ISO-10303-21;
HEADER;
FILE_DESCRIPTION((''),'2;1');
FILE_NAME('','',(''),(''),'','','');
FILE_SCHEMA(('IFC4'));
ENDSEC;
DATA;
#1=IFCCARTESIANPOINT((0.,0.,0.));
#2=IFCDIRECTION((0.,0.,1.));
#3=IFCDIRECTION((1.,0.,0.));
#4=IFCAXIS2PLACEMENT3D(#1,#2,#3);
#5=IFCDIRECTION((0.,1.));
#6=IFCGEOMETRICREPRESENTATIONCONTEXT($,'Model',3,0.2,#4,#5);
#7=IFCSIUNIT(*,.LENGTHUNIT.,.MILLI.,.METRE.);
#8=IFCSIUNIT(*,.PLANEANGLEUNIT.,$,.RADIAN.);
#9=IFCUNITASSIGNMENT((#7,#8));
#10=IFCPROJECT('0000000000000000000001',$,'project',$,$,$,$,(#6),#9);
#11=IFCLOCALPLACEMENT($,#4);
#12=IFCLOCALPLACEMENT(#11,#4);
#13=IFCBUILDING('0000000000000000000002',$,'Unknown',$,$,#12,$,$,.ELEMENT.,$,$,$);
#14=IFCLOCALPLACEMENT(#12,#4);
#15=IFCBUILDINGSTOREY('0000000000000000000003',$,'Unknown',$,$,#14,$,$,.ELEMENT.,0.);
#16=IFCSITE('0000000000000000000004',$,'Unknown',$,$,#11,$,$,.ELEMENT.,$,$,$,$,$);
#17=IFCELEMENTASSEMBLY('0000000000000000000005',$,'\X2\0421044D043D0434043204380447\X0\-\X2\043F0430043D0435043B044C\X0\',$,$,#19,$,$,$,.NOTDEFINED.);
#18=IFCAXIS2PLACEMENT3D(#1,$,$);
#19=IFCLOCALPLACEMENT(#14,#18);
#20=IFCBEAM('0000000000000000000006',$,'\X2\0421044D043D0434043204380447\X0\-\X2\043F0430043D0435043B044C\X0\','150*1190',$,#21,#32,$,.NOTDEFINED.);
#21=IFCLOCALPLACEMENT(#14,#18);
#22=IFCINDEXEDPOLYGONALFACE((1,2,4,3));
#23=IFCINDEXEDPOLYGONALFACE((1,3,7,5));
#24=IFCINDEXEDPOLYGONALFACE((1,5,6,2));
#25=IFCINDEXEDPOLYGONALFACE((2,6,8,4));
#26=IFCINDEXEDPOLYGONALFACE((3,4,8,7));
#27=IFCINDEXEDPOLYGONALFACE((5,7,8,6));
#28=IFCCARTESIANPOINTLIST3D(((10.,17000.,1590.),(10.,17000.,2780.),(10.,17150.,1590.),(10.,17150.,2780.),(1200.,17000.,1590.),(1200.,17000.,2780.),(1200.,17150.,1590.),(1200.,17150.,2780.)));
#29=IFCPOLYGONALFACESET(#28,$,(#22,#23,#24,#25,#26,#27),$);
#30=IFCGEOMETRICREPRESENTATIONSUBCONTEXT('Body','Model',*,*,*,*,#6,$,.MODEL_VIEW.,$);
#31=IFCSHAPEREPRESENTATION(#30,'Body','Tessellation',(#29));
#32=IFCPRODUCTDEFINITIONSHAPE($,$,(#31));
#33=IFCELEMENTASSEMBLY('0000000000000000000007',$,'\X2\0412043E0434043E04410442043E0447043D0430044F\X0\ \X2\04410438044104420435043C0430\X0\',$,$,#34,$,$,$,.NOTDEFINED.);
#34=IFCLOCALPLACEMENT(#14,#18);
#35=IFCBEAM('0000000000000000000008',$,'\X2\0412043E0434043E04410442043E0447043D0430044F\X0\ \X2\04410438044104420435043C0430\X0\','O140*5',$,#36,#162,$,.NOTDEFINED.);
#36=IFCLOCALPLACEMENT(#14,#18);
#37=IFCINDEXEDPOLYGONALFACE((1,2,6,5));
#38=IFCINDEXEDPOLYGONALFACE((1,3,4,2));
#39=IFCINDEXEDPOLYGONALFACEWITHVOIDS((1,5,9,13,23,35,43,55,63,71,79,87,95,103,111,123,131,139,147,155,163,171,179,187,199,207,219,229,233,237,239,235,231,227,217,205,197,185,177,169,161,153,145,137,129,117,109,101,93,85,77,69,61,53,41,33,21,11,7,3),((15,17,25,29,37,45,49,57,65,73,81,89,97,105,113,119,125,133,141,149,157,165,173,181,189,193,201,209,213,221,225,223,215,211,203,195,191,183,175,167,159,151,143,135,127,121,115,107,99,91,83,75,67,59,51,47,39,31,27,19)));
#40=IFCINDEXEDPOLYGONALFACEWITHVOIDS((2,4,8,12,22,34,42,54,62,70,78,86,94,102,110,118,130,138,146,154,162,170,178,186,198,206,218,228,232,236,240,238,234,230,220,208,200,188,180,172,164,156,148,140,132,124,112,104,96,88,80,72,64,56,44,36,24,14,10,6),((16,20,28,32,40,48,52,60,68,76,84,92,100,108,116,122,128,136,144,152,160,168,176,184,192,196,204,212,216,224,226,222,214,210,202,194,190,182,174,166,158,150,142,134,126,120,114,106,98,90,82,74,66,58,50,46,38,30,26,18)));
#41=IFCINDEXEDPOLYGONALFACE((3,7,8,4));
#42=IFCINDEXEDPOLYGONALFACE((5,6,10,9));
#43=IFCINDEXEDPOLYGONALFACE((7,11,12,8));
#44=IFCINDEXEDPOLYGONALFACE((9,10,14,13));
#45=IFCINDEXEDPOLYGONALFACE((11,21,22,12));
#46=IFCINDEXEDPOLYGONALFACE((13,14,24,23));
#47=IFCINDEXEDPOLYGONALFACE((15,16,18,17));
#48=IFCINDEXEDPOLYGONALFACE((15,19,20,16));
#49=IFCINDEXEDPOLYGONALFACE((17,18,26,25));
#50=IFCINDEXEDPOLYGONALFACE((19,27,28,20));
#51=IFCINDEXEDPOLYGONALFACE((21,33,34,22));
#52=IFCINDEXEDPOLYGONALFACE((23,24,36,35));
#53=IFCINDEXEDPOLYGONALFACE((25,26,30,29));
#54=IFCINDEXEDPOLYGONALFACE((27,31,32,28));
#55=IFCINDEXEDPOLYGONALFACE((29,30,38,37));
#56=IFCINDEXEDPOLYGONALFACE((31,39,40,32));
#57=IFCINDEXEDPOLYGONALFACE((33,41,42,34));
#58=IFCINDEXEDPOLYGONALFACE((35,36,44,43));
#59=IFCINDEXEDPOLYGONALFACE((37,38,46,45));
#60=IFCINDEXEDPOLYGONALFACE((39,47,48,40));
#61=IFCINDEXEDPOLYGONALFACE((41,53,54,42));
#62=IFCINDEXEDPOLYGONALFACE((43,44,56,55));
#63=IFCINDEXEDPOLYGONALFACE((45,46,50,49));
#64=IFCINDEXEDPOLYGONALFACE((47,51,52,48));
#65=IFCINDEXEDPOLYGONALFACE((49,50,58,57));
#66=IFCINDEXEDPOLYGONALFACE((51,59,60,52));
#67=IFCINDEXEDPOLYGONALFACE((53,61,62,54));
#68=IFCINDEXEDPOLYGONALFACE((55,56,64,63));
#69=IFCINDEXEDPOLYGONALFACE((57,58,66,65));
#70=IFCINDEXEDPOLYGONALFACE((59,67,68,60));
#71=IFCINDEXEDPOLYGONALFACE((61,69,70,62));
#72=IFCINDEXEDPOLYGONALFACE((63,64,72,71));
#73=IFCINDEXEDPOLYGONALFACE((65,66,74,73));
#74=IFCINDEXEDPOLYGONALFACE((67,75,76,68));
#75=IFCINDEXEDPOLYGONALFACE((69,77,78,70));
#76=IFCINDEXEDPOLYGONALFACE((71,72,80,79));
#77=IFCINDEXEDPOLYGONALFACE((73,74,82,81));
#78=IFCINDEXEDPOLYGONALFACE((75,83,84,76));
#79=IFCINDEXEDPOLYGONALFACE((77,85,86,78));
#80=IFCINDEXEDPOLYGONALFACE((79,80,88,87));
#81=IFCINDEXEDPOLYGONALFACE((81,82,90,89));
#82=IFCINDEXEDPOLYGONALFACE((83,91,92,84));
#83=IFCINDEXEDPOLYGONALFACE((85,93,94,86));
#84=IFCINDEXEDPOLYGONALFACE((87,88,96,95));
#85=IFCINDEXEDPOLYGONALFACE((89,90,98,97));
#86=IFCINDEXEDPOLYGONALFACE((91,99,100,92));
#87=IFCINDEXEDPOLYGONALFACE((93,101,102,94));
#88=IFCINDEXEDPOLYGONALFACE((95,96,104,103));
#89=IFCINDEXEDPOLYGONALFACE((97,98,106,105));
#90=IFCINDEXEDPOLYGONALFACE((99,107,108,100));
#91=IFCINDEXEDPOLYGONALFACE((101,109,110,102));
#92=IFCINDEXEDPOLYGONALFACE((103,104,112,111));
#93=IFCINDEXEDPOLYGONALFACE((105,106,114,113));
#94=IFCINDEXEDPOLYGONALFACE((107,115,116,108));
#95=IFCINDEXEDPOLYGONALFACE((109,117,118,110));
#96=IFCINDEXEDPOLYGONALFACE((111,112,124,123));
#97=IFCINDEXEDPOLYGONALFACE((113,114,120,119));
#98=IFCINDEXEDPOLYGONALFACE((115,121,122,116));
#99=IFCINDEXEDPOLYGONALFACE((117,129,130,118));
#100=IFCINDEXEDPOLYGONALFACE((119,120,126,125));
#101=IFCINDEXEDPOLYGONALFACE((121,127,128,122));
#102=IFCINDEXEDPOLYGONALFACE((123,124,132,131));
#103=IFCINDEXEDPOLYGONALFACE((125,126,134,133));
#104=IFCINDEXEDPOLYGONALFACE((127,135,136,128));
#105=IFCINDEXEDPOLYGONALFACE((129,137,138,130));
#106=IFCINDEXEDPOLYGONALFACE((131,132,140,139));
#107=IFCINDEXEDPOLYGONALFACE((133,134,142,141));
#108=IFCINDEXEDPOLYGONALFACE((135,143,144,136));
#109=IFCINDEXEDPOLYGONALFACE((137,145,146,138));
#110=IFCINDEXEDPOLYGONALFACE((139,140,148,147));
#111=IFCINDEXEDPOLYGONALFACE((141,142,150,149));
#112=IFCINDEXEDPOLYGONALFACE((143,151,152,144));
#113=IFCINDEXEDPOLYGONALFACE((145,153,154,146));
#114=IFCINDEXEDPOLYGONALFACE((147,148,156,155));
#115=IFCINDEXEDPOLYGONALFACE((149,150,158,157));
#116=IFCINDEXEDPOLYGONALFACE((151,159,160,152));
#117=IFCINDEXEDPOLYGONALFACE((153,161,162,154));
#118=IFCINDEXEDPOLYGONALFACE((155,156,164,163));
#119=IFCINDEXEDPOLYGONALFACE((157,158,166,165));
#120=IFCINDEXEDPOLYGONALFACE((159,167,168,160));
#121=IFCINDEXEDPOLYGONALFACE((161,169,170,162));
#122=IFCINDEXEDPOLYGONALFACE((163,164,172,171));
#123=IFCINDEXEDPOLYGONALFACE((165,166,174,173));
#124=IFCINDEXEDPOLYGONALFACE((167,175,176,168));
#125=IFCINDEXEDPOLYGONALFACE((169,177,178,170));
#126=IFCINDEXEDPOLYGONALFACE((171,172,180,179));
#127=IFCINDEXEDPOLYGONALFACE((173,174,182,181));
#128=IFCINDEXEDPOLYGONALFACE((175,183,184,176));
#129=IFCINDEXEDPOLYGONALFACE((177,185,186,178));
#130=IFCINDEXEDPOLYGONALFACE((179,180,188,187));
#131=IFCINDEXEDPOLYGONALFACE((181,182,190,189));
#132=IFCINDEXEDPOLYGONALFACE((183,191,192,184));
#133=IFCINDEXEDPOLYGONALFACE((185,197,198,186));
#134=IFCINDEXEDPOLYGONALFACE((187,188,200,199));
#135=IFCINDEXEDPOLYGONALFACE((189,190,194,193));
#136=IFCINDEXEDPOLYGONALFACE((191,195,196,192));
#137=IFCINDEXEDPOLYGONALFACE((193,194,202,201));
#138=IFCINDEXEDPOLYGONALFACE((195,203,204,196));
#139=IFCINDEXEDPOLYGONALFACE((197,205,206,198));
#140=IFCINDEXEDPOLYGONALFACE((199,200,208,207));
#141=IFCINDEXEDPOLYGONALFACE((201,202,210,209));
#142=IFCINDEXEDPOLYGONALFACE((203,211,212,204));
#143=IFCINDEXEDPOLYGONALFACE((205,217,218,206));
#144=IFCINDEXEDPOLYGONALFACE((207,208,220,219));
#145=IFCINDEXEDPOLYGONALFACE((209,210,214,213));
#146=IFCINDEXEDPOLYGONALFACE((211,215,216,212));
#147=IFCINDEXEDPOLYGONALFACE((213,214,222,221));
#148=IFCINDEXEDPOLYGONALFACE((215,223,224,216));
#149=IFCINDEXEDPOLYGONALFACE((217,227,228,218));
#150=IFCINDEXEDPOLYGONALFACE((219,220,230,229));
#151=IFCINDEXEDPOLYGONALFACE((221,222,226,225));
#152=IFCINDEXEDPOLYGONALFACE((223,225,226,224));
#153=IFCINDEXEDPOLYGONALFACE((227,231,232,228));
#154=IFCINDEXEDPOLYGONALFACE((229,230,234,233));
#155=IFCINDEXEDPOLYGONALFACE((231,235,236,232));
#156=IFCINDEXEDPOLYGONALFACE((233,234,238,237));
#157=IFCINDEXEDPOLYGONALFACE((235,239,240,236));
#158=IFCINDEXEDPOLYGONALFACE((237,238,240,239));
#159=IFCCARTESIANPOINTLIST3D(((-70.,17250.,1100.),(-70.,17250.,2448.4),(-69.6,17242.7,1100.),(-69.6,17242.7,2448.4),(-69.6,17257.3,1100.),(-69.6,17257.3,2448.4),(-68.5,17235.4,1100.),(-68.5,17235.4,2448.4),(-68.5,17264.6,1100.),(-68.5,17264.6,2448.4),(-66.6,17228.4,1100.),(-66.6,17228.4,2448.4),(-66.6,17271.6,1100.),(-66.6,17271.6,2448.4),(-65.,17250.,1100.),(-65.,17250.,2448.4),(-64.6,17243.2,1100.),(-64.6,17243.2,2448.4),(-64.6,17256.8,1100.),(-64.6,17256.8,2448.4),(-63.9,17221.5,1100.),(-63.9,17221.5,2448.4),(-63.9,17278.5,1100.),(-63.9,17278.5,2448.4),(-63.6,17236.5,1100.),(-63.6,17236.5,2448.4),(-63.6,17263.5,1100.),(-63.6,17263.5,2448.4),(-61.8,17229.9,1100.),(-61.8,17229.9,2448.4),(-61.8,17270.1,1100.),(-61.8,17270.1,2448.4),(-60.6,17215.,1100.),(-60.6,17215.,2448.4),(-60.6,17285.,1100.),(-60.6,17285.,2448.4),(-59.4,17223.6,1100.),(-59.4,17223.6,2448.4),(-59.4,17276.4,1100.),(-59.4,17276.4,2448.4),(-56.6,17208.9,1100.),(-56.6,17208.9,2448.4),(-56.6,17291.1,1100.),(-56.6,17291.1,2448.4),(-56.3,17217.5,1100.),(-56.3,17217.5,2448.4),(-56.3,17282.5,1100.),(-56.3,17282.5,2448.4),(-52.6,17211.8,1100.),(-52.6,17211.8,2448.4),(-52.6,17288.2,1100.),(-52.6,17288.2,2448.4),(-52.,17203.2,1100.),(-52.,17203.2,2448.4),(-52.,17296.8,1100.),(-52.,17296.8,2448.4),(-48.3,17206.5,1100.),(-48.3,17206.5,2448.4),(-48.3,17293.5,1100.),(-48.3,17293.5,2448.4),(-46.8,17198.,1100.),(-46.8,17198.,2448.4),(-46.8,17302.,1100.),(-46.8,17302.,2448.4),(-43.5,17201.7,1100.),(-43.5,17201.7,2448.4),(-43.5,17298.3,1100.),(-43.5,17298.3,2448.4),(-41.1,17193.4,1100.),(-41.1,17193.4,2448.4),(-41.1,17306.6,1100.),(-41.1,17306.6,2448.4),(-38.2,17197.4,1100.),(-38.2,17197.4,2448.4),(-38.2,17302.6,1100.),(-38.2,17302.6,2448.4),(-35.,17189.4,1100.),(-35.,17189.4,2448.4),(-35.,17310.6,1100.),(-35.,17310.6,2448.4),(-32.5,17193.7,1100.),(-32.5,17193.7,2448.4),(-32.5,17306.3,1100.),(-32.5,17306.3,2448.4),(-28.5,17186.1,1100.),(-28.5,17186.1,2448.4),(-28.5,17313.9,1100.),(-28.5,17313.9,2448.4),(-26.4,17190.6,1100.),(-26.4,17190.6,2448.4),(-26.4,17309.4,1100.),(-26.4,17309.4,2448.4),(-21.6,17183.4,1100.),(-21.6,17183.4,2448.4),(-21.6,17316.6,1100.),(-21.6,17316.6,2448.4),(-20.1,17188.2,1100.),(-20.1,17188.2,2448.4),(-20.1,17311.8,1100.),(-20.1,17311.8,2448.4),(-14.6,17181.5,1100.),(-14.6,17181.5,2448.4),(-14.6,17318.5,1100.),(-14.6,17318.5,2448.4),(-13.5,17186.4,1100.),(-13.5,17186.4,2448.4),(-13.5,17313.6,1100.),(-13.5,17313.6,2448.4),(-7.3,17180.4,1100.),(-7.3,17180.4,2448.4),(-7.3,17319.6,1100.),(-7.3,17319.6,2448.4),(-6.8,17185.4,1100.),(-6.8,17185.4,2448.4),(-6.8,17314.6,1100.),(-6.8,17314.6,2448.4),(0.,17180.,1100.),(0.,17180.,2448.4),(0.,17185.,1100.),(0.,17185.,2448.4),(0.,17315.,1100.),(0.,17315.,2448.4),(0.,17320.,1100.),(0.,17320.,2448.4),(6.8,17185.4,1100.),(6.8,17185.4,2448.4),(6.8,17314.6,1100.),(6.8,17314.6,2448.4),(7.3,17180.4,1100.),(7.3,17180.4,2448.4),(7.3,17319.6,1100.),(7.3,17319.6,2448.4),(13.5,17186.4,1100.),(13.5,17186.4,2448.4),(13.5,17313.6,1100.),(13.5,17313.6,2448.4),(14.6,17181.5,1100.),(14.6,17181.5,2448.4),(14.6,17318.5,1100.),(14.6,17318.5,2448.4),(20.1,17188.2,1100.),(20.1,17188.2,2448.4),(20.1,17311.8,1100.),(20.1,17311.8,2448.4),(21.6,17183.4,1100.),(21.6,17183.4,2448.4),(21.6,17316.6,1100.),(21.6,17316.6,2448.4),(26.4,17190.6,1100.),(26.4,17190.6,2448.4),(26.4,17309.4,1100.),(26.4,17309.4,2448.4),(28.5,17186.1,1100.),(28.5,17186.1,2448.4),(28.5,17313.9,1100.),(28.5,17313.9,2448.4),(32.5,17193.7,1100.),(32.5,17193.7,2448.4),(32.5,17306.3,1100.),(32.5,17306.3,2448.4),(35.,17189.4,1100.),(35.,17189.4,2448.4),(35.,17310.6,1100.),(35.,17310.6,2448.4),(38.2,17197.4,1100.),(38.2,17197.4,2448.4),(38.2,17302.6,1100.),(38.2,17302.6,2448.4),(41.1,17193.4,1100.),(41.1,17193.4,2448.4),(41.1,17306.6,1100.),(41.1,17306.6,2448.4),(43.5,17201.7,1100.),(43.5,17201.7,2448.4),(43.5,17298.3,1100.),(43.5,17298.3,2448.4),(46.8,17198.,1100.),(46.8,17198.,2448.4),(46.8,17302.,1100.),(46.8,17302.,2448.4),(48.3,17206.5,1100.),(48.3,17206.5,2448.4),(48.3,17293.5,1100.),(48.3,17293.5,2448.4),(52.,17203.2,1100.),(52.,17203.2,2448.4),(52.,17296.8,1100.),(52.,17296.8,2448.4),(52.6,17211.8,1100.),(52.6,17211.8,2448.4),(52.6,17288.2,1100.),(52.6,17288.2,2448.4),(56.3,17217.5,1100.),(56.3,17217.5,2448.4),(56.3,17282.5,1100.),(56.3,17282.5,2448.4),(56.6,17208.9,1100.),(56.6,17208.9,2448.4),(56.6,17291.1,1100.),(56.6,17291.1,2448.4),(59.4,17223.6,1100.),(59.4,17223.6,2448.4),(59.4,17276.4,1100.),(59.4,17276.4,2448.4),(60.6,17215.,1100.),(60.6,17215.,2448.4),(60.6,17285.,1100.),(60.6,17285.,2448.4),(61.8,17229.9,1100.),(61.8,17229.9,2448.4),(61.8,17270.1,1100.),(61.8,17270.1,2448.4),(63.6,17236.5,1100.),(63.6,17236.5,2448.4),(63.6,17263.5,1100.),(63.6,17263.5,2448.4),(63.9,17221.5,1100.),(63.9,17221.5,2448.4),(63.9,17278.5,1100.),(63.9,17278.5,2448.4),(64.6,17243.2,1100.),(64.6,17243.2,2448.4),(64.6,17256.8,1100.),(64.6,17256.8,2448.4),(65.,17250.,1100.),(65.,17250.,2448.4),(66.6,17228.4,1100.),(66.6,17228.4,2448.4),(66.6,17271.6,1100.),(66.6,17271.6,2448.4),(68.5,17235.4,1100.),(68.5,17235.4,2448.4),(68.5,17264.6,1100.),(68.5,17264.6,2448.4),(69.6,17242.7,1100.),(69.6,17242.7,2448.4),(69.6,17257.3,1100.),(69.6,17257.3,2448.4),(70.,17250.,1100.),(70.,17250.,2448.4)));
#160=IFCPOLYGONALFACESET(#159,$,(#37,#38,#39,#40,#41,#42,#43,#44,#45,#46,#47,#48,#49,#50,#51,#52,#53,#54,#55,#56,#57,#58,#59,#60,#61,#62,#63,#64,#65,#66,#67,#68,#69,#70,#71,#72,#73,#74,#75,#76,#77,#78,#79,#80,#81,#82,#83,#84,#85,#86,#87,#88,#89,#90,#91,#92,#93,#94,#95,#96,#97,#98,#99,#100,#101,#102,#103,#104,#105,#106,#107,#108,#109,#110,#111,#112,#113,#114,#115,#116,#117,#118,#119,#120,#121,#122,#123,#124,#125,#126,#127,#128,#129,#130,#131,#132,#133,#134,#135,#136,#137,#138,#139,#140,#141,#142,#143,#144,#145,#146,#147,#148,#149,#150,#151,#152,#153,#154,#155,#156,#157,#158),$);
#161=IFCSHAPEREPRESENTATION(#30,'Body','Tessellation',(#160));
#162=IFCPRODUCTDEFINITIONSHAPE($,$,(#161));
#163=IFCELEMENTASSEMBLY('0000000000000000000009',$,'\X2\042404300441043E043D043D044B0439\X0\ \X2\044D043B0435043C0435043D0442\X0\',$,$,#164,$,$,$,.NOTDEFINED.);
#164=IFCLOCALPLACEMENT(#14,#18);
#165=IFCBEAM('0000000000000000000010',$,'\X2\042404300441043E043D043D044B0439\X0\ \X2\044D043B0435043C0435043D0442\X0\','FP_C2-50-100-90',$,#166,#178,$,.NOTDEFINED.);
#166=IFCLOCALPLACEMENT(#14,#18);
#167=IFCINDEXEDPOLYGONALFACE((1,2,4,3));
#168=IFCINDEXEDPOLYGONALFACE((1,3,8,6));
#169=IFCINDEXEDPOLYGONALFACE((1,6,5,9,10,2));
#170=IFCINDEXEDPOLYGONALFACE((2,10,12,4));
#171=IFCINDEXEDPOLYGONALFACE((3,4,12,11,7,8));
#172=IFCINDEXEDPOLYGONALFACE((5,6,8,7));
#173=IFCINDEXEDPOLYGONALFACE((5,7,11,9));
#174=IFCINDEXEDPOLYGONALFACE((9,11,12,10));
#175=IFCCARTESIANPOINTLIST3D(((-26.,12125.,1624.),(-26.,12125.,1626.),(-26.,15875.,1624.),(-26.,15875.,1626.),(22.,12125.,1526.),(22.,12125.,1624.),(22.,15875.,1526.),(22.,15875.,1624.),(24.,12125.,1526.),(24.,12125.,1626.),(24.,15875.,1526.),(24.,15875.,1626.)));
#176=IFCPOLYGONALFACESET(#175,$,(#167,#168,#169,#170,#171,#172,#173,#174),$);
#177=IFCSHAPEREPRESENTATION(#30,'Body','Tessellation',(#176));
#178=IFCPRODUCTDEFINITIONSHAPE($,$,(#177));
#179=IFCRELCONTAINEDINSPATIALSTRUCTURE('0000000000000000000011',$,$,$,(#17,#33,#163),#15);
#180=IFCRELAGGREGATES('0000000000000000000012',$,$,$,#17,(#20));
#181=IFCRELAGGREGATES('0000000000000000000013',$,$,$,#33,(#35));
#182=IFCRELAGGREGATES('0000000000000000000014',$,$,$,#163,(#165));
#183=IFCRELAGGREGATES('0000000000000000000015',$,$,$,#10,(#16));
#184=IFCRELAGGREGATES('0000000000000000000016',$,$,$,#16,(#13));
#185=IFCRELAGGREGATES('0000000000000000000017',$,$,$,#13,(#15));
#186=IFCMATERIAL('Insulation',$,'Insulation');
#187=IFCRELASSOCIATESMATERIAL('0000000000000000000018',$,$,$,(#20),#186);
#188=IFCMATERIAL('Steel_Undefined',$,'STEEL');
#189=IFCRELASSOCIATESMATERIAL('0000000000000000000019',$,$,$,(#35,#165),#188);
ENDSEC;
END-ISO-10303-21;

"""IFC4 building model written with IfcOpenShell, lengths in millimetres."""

from ifc_helpers import new_model, si_unit, direction, frame, origin_with_axes, place, context, subcontext, project, spatial, line, indexed_curve, outline, extrude, material, element, aggregate, save


model = new_model("IFC4")

# Units and contexts
model_context = context("Model", 3, precision=0.2, world=origin_with_axes(), true_north=direction((0.0, 1.0)))
body_context = subcontext(model_context, "Body", "Model", "MODEL_VIEW")
ifc_project = project(units=[si_unit("LENGTHUNIT", "METRE", prefix="MILLI"), si_unit("PLANEANGLEUNIT", "RADIAN")], contexts=[model_context])

# Site, building, storey
site_placement = place(None, origin_with_axes())
site = spatial("IfcSite", under=ifc_project, at=site_placement, Name="Unknown", CompositionType="ELEMENT")
building_placement = place(site_placement, origin_with_axes())
building = spatial("IfcBuilding", under=site, at=building_placement, Name="Unknown", CompositionType="ELEMENT")
storey_placement = place(building_placement, origin_with_axes())
storey = spatial("IfcBuildingStorey", under=building, at=storey_placement, Name="Unknown", CompositionType="ELEMENT", Elevation=0.0)

# Element assemblies, beams
assembly_1_placement = place(storey_placement, frame((10.0, 17075.0, 2185.0), z_axis=(0.0, 0.0, -1.0), x_axis=(1.0, 0.0, 0.0)))
assembly_1 = element("IfcElementAssembly", 1, at=assembly_1_placement, inside=storey, Name="Сэндвич-панель", PredefinedType="NOTDEFINED")
ifc_material_1 = material(Name="Insulation", Category="Insulation")
beam_1_placement = place(assembly_1_placement, origin_with_axes())
beam_1 = element("IfcBeam", 2, at=beam_1_placement, material=ifc_material_1, Name="Сэндвич-панель", Description="150*1190", PredefinedType="NOTDEFINED", context=body_context, shape_type="SolidModel", body=[
    extrude(outline(indexed_curve([(-595.0, -75.0), (595.0, -75.0), (595.0, 75.0), (-595.0, 75.0)], segments=[line(1, 2, 3, 4, 1)])), frame((0.0, 0.0, 0.0), z_axis=(-1.0, 0.0, 0.0), x_axis=(0.0, 0.0, 1.0)), (0.0, 0.0, -1.0), 1190.0),
])
aggregate(assembly_1, [beam_1])
assembly_2_placement = place(storey_placement, frame((0.0, 17250.0, 2448.4), z_axis=(0.0, -1.0, 0.0), x_axis=(0.0, 0.0, -1.0)))
assembly_2 = element("IfcElementAssembly", 3, at=assembly_2_placement, inside=storey, Name="Водосточная система", PredefinedType="NOTDEFINED")
ifc_material_2 = material(Name="Steel_Undefined", Category="STEEL")
beam_2_placement = place(assembly_2_placement, origin_with_axes())
beam_2 = element("IfcBeam", 4, at=beam_2_placement, material=ifc_material_2, Name="Водосточная система", Description="O140*5", PredefinedType="NOTDEFINED", context=body_context, shape_type="SolidModel", body=[
    extrude(outline(indexed_curve([(70.0, 0.0), (69.6, 7.3), (68.5, 14.6), (66.6, 21.6), (63.9, 28.5), (60.6, 35.0), (56.6, 41.1), (52.0, 46.8), (46.8, 52.0), (41.1, 56.6), (35.0, 60.6), (28.5, 63.9), (21.6, 66.6), (14.6, 68.5), (7.3, 69.6), (0.0, 70.0), (-7.3, 69.6), (-14.6, 68.5), (-21.6, 66.6), (-28.5, 63.9), (-35.0, 60.6), (-41.1, 56.6), (-46.8, 52.0), (-52.0, 46.8), (-56.6, 41.1), (-60.6, 35.0), (-63.9, 28.5), (-66.6, 21.6), (-68.5, 14.6), (-69.6, 7.3), (-70.0, 0.0), (-69.6, -7.3), (-68.5, -14.6), (-66.6, -21.6), (-63.9, -28.5), (-60.6, -35.0), (-56.6, -41.1), (-52.0, -46.8), (-46.8, -52.0), (-41.1, -56.6), (-35.0, -60.6), (-28.5, -63.9), (-21.6, -66.6), (-14.6, -68.5), (-7.3, -69.6), (0.0, -70.0), (7.3, -69.6), (14.6, -68.5), (21.6, -66.6), (28.5, -63.9), (35.0, -60.6), (41.1, -56.6), (46.8, -52.0), (52.0, -46.8), (56.6, -41.1), (60.6, -35.0), (63.9, -28.5), (66.6, -21.6), (68.5, -14.6), (69.6, -7.3)], segments=[line(1, 2, 3, 4, 5, 6, 7, 8, 9, 10, 11, 12, 13, 14, 15, 16, 17, 18, 19, 20, 21, 22, 23, 24, 25, 26, 27, 28, 29, 30, 31, 32, 33, 34, 35, 36, 37, 38, 39, 40, 41, 42, 43, 44, 45, 46, 47, 48, 49, 50, 51, 52, 53, 54, 55, 56, 57, 58, 59, 60, 1)]), holes=[indexed_curve([(65.0, 0.0), (64.6, -6.8), (63.6, -13.5), (61.8, -20.1), (59.4, -26.4), (56.3, -32.5), (52.6, -38.2), (48.3, -43.5), (43.5, -48.3), (38.2, -52.6), (32.5, -56.3), (26.4, -59.4), (20.1, -61.8), (13.5, -63.6), (6.8, -64.6), (0.0, -65.0), (-6.8, -64.6), (-13.5, -63.6), (-20.1, -61.8), (-26.4, -59.4), (-32.5, -56.3), (-38.2, -52.6), (-43.5, -48.3), (-48.3, -43.5), (-52.6, -38.2), (-56.3, -32.5), (-59.4, -26.4), (-61.8, -20.1), (-63.6, -13.5), (-64.6, -6.8), (-65.0, 0.0), (-64.6, 6.8), (-63.6, 13.5), (-61.8, 20.1), (-59.4, 26.4), (-56.3, 32.5), (-52.6, 38.2), (-48.3, 43.5), (-43.5, 48.3), (-38.2, 52.6), (-32.5, 56.3), (-26.4, 59.4), (-20.1, 61.8), (-13.5, 63.6), (-6.8, 64.6), (0.0, 65.0), (6.8, 64.6), (13.5, 63.6), (20.1, 61.8), (26.4, 59.4), (32.5, 56.3), (38.2, 52.6), (43.5, 48.3), (48.3, 43.5), (52.6, 38.2), (56.3, 32.5), (59.4, 26.4), (61.8, 20.1), (63.6, 13.5), (64.6, 6.8)], segments=[line(1, 2, 3, 4, 5, 6, 7, 8, 9, 10, 11, 12, 13, 14, 15, 16, 17, 18, 19, 20, 21, 22, 23, 24, 25, 26, 27, 28, 29, 30, 31, 32, 33, 34, 35, 36, 37, 38, 39, 40, 41, 42, 43, 44, 45, 46, 47, 48, 49, 50, 51, 52, 53, 54, 55, 56, 57, 58, 59, 60, 1)])]), frame((0.0, 0.0, 0.0), z_axis=(-1.0, 0.0, 0.0), x_axis=(0.0, 0.0, 1.0)), (0.0, 0.0, -1.0), 1348.4),
])
aggregate(assembly_2, [beam_2])
assembly_3_placement = place(storey_placement, frame((-1.0, 15875.0, 1625.0), z_axis=(1.0, 0.0, 0.0), x_axis=(0.0, -1.0, 0.0)))
assembly_3 = element("IfcElementAssembly", 5, at=assembly_3_placement, inside=storey, Name="Фасонный элемент", PredefinedType="NOTDEFINED")
beam_3_placement = place(assembly_3_placement, origin_with_axes())
beam_3 = element("IfcBeam", 6, at=beam_3_placement, material=ifc_material_2, Name="Фасонный элемент", Description="FP_C2-50-100-90", PredefinedType="NOTDEFINED", context=body_context, shape_type="SolidModel", body=[
    extrude(outline(indexed_curve([(-25.0, -1.0), (25.0, -1.0), (25.0, 99.0), (23.0, 99.0), (23.0, 1.0), (-25.0, 1.0)], segments=[line(1, 2, 3, 4, 5, 6, 1)])), frame((0.0, 0.0, 0.0), z_axis=(-1.0, 0.0, 0.0), x_axis=(0.0, 0.0, 1.0)), (0.0, 0.0, -1.0), 3750.0),
])
aggregate(assembly_3, [beam_3])

save(model, "model.ifc")
